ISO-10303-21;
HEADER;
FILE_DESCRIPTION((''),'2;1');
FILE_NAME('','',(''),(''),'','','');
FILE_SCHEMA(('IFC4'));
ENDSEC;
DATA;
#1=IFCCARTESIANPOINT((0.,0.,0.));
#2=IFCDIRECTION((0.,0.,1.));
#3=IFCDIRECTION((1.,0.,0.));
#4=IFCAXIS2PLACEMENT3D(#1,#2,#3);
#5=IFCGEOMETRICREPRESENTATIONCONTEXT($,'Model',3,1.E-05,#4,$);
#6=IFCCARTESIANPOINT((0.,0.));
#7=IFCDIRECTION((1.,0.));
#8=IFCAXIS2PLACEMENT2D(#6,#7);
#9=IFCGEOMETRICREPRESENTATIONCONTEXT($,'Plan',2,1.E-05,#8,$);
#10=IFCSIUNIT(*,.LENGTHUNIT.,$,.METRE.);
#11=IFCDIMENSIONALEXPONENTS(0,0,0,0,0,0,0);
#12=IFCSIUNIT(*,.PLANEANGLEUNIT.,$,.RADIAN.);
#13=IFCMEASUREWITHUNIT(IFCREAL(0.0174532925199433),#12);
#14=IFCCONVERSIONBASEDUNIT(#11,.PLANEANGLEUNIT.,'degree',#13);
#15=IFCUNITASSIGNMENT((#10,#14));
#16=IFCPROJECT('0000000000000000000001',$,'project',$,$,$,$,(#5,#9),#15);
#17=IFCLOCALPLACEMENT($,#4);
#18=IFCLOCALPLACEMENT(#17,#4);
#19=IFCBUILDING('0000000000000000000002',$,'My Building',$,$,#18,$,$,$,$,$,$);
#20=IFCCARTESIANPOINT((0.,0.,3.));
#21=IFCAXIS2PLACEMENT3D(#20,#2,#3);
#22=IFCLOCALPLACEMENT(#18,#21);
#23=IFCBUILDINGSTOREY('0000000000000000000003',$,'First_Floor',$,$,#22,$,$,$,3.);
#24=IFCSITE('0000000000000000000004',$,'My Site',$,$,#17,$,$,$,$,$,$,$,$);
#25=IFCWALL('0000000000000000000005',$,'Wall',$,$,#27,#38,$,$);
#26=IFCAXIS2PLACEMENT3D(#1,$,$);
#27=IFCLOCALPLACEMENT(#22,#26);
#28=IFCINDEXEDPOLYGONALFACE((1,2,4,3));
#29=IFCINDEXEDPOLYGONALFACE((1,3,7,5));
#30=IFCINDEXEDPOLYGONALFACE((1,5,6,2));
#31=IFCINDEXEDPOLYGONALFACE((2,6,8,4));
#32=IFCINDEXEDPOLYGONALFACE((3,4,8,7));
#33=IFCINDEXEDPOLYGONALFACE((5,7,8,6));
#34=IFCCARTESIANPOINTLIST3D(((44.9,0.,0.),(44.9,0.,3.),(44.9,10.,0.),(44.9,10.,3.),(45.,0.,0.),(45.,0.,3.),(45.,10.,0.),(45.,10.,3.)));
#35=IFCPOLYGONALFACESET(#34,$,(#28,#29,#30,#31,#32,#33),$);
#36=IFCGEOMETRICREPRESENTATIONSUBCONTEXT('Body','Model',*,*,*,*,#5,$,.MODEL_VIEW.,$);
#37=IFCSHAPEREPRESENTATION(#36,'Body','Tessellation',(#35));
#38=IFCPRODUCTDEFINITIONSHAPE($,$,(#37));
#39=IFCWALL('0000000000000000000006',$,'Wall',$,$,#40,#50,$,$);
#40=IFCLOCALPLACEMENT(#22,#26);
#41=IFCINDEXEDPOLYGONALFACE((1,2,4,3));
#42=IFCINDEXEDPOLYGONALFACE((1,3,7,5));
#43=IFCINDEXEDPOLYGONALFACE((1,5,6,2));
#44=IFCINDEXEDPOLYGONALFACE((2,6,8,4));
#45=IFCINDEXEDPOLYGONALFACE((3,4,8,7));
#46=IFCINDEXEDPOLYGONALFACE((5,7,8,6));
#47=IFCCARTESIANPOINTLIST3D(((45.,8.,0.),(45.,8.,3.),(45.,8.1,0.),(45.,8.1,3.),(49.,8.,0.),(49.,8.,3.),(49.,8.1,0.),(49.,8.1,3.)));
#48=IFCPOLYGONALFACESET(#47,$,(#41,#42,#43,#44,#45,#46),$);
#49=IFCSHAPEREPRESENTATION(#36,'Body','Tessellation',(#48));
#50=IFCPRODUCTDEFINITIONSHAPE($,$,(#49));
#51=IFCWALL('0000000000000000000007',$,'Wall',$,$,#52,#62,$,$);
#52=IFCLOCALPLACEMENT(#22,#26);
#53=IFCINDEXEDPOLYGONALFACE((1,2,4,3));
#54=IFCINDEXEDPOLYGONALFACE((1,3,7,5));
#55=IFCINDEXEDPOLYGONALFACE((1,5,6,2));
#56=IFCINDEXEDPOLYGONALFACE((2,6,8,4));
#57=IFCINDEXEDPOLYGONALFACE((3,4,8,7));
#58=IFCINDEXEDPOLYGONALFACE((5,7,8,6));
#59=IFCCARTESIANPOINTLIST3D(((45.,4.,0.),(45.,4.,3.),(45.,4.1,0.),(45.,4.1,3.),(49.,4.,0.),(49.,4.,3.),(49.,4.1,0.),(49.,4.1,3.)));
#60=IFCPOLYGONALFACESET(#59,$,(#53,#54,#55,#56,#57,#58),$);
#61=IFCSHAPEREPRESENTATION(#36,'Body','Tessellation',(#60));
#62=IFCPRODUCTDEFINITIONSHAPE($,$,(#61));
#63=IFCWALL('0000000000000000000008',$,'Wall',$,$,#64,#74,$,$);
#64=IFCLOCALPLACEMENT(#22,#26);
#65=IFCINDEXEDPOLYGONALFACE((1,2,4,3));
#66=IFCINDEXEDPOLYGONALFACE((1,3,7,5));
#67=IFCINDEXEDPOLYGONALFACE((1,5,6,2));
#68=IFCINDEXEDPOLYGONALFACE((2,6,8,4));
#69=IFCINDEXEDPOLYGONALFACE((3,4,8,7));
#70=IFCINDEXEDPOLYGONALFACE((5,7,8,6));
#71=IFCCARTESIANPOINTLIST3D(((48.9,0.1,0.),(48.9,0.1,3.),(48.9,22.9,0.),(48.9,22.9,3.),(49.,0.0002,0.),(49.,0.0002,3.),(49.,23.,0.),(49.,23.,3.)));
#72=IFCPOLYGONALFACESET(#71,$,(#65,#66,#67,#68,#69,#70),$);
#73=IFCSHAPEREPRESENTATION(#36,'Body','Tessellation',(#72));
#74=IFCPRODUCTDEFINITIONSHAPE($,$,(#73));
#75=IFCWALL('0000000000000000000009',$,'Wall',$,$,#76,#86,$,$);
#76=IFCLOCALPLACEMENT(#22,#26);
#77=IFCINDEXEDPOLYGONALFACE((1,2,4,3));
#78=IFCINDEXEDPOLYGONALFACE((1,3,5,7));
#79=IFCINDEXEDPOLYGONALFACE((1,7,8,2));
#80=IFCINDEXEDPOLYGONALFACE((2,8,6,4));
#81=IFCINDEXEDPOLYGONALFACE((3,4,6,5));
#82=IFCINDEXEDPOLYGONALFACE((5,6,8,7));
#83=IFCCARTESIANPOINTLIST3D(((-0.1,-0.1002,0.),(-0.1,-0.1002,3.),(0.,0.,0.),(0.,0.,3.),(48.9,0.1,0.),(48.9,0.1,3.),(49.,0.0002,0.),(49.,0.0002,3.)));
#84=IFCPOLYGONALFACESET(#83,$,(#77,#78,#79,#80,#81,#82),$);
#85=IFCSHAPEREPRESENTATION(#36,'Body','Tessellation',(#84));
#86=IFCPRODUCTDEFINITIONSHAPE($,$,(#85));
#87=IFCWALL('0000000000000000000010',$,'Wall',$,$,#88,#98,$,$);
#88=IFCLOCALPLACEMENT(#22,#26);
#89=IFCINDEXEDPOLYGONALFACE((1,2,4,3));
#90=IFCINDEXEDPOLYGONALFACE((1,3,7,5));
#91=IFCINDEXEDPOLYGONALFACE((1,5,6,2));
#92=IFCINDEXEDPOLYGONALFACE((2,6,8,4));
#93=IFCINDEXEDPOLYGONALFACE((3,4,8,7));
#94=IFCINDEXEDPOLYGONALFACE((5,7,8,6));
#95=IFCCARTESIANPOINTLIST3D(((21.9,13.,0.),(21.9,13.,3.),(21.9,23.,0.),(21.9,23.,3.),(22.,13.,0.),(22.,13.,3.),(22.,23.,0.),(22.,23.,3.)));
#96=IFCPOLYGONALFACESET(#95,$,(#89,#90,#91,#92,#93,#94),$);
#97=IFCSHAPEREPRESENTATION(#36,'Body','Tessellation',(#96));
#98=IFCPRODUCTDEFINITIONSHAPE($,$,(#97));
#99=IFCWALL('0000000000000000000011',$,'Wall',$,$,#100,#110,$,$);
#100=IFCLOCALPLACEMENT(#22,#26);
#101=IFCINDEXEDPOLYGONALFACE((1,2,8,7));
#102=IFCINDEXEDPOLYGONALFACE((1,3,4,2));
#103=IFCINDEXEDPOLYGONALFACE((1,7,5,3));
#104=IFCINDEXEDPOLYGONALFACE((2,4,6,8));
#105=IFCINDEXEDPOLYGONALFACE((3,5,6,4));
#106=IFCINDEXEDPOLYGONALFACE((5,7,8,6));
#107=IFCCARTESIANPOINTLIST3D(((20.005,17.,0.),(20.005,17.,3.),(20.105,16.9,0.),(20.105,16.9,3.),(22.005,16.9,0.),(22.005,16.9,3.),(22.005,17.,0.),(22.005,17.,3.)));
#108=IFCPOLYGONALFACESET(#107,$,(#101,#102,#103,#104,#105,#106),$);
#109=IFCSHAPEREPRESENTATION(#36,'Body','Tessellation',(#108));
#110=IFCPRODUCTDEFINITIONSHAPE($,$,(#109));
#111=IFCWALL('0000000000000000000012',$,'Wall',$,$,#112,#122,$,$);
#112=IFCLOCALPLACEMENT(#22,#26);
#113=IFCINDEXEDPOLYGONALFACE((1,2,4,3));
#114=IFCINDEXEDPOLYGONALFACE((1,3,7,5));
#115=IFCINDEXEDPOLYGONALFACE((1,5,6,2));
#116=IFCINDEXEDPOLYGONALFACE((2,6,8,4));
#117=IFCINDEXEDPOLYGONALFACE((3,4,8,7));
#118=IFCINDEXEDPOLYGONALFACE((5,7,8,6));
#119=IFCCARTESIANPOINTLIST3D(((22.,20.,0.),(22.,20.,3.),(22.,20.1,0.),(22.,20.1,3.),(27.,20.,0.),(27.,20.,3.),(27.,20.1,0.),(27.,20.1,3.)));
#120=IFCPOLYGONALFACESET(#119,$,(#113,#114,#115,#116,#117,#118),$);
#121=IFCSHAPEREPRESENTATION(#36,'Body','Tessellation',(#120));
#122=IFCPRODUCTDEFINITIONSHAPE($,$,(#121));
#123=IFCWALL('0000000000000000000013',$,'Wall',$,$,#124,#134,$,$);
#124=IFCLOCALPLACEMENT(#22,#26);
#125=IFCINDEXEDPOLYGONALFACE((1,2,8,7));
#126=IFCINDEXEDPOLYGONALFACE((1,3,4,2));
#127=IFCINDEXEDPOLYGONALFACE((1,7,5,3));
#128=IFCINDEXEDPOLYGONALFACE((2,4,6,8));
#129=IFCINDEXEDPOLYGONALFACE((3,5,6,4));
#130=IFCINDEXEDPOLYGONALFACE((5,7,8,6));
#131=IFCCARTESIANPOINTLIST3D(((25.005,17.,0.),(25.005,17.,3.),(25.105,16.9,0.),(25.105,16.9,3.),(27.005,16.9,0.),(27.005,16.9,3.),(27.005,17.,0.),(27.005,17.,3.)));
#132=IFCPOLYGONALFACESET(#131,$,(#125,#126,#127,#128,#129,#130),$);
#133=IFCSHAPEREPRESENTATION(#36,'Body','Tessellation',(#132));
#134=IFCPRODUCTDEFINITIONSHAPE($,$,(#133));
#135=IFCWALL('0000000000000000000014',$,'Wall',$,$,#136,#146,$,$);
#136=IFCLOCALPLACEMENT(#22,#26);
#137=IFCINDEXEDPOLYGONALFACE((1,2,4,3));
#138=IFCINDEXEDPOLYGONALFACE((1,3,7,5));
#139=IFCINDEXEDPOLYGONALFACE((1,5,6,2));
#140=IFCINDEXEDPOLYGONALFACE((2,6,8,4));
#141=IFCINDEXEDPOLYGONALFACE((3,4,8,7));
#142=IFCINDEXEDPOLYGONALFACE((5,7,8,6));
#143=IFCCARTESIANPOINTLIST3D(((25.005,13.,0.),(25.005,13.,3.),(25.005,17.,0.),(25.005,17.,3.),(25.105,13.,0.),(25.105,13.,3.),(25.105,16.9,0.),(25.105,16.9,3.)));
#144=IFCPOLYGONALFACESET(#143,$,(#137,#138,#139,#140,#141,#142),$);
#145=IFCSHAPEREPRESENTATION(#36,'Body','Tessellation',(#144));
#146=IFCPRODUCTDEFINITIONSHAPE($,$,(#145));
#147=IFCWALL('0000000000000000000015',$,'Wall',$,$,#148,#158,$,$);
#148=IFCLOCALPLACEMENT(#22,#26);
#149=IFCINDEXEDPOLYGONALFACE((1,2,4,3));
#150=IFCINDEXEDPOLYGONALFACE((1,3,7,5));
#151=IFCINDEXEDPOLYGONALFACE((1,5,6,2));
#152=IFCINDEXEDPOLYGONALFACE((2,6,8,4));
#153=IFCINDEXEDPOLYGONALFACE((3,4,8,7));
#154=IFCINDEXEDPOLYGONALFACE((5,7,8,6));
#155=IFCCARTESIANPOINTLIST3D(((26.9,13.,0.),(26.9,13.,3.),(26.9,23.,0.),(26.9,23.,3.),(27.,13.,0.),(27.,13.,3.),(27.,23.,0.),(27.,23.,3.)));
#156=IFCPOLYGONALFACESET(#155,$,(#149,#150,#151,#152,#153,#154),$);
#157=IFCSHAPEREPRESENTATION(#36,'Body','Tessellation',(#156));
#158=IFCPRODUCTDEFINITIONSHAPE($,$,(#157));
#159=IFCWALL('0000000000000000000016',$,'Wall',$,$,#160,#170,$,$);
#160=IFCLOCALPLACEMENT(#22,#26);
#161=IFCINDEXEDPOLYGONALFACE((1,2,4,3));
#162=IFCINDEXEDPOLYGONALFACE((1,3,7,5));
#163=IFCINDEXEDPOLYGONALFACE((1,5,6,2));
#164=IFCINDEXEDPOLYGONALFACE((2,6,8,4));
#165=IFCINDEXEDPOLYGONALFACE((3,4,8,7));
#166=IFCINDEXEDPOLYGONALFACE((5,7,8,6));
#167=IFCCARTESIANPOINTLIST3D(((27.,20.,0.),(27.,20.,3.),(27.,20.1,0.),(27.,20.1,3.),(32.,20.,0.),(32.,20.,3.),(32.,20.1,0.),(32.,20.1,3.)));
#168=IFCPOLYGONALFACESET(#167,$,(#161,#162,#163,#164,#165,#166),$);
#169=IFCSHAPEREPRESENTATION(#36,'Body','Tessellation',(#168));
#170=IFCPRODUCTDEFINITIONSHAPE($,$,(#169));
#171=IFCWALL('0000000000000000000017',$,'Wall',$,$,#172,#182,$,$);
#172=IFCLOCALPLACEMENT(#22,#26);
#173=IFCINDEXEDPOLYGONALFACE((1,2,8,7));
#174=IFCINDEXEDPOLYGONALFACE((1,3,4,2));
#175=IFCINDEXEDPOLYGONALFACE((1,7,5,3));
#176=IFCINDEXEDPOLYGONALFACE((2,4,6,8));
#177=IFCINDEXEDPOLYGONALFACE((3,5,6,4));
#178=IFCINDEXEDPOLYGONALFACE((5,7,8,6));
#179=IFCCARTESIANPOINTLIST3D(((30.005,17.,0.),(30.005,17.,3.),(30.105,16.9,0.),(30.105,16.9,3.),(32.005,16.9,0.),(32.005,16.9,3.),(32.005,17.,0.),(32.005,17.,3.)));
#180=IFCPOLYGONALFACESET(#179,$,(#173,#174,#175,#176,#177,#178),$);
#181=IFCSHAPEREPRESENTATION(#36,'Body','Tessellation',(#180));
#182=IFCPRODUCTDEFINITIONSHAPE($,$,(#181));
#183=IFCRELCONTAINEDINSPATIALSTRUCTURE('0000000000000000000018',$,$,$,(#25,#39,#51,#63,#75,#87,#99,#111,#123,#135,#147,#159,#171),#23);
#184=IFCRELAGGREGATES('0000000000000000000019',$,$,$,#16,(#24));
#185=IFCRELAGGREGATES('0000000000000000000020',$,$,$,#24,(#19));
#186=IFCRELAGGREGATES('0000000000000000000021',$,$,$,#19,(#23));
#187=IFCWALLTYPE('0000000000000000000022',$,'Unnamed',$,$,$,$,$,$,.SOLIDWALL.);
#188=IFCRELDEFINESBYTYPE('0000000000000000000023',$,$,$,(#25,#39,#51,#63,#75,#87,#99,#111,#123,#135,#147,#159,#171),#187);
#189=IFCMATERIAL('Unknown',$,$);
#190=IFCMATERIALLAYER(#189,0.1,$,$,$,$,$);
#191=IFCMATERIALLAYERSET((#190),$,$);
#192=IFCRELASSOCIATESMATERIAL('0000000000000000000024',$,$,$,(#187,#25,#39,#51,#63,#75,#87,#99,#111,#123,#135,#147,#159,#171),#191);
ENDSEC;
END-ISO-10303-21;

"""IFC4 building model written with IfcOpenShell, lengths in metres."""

from ifc_helpers import new_model, entity, si_unit, converted_unit, frame, origin_with_axes, origin_2d_with_axis, place, context, subcontext, project, spatial, line, indexed_curve, outline, extrude, material, layer, layer_set, layer_usage, type_object, element, save


model = new_model("IFC4")

# Units and contexts
model_context = context("Model", 3, precision=1e-05, world=origin_with_axes())
plan_context = context("Plan", 2, precision=1e-05, world=origin_2d_with_axis())
body_context = subcontext(model_context, "Body", "Model", "MODEL_VIEW")
ifc_project = project(units=[si_unit("LENGTHUNIT", "METRE"), converted_unit("PLANEANGLEUNIT", "degree", entity("IfcReal", 0.0174532925199433), si_unit("PLANEANGLEUNIT", "RADIAN"), dimensions=[0, 0, 0, 0, 0, 0, 0])], contexts=[model_context, plan_context])

# Site, building, storey
site_placement = place(None, origin_with_axes())
site = spatial("IfcSite", under=ifc_project, at=site_placement, Name="My Site")
building_placement = place(site_placement, origin_with_axes())
building = spatial("IfcBuilding", under=site, at=building_placement, Name="My Building")
storey_placement = place(building_placement, frame((0.0, 0.0, 3.0), z_axis=(0.0, 0.0, 1.0), x_axis=(1.0, 0.0, 0.0)))
storey = spatial("IfcBuildingStorey", under=building, at=storey_placement, Name="First_Floor", Elevation=3.0)

# Shared definitions
ifc_material = material(Name="Unknown")

# Walls
ifc_layer_1 = layer(ifc_material, 0.1)
ifc_layer_set_1 = layer_set([ifc_layer_1])
wall_type = type_object("IfcWallType", Name="Unnamed", PredefinedType="SOLIDWALL", material=ifc_layer_set_1)
ifc_layer_usage_1 = layer_usage(ifc_layer_set_1, "AXIS2", "POSITIVE", 0.0)
wall_1_placement = place(storey_placement, frame((44.9, 10.0, 0.0), z_axis=(0.0, 0.0, 1.0), x_axis=(0.0, -1.0, 0.0)))
element("IfcWall", 1, at=wall_1_placement, inside=storey, type_object=wall_type, material=ifc_layer_usage_1, Name="Wall", context=body_context, shape_type="SweptSolid", body=[
    extrude(outline(indexed_curve([(0.0, 0.0), (0.0, 0.1), (10.0, 0.1), (10.0, 0.0)], segments=[line(1, 2, 3, 4, 1)])), origin_with_axes(), (0.0, 0.0, 1.0), 3.0),
])
ifc_layer_usage_2 = layer_usage(ifc_layer_set_1, "AXIS2", "POSITIVE", 0.0)
wall_2_placement = place(storey_placement, frame((45.0, 8.0, 0.0), z_axis=(0.0, 0.0, 1.0), x_axis=(1.0, 0.0, 0.0)))
element("IfcWall", 2, at=wall_2_placement, inside=storey, type_object=wall_type, material=ifc_layer_usage_2, Name="Wall", context=body_context, shape_type="SweptSolid", body=[
    extrude(outline(indexed_curve([(0.0, 0.0), (0.0, 0.1), (4.0, 0.1), (4.0, 0.0)], segments=[line(1, 2, 3, 4, 1)])), origin_with_axes(), (0.0, 0.0, 1.0), 3.0),
])
ifc_layer_usage_3 = layer_usage(ifc_layer_set_1, "AXIS2", "POSITIVE", 0.0)
wall_3_placement = place(storey_placement, frame((45.0, 4.0, 0.0), z_axis=(0.0, 0.0, 1.0), x_axis=(1.0, 0.0, 0.0)))
element("IfcWall", 3, at=wall_3_placement, inside=storey, type_object=wall_type, material=ifc_layer_usage_3, Name="Wall", context=body_context, shape_type="SweptSolid", body=[
    extrude(outline(indexed_curve([(0.0, 0.0), (0.0, 0.1), (4.0, 0.1), (4.0, 0.0)], segments=[line(1, 2, 3, 4, 1)])), origin_with_axes(), (0.0, 0.0, 1.0), 3.0),
])
ifc_layer_usage_4 = layer_usage(ifc_layer_set_1, "AXIS2", "POSITIVE", 0.0)
wall_4_placement = place(storey_placement, frame((48.9, 22.9, 0.0), z_axis=(0.0, 0.0, 1.0), x_axis=(0.0, -1.0, 0.0)))
element("IfcWall", 4, at=wall_4_placement, inside=storey, type_object=wall_type, material=ifc_layer_usage_4, Name="Wall", context=body_context, shape_type="SweptSolid", body=[
    extrude(outline(indexed_curve([(0.0, 0.0), (-0.1, 0.1), (22.8998, 0.1), (22.8, 0.0)], segments=[line(1, 2, 3, 4, 1)])), origin_with_axes(), (0.0, 0.0, 1.0), 3.0),
])
ifc_layer_usage_5 = layer_usage(ifc_layer_set_1, "AXIS2", "POSITIVE", 0.0)
wall_5_placement = place(storey_placement, frame((48.9, 0.1, 0.0), z_axis=(0.0, 0.0, 1.0), x_axis=(-0.999998, -0.002045, 0.0)))
element("IfcWall", 5, at=wall_5_placement, inside=storey, type_object=wall_type, material=ifc_layer_usage_5, Name="Wall", context=body_context, shape_type="SweptSolid", body=[
    extrude(outline(indexed_curve([(0.0, 0.0), (-0.0998, 0.1), (49.0003, 0.1), (48.9001, 0.0)], segments=[line(1, 2, 3, 4, 1)])), origin_with_axes(), (0.0, 0.0, 1.0), 3.0),
])
ifc_layer_usage_6 = layer_usage(ifc_layer_set_1, "AXIS2", "POSITIVE", 0.0)
wall_6_placement = place(storey_placement, frame((21.9, 23.0, 0.0), z_axis=(0.0, 0.0, 1.0), x_axis=(0.0, -1.0, 0.0)))
element("IfcWall", 6, at=wall_6_placement, inside=storey, type_object=wall_type, material=ifc_layer_usage_6, Name="Wall", context=body_context, shape_type="SweptSolid", body=[
    extrude(outline(indexed_curve([(0.0, 0.0), (0.0, 0.1), (10.0, 0.1), (10.0, 0.0)], segments=[line(1, 2, 3, 4, 1)])), origin_with_axes(), (0.0, 0.0, 1.0), 3.0),
])
ifc_layer_usage_7 = layer_usage(ifc_layer_set_1, "AXIS2", "POSITIVE", 0.0)
wall_7_placement = place(storey_placement, frame((22.005, 17.0, 0.0), z_axis=(0.0, 0.0, 1.0), x_axis=(-1.0, 0.0, 0.0)))
element("IfcWall", 7, at=wall_7_placement, inside=storey, type_object=wall_type, material=ifc_layer_usage_7, Name="Wall", context=body_context, shape_type="SweptSolid", body=[
    extrude(outline(indexed_curve([(0.0, 0.0), (0.0, 0.1), (1.9, 0.1), (2.0, 0.0)], segments=[line(1, 2, 3, 4, 1)])), origin_with_axes(), (0.0, 0.0, 1.0), 3.0),
])
ifc_layer_usage_8 = layer_usage(ifc_layer_set_1, "AXIS2", "POSITIVE", 0.0)
wall_8_placement = place(storey_placement, frame((22.0, 20.0, 0.0), z_axis=(0.0, 0.0, 1.0), x_axis=(1.0, 0.0, 0.0)))
element("IfcWall", 8, at=wall_8_placement, inside=storey, type_object=wall_type, material=ifc_layer_usage_8, Name="Wall", context=body_context, shape_type="SweptSolid", body=[
    extrude(outline(indexed_curve([(0.0, 0.0), (0.0, 0.1), (5.0, 0.1), (5.0, 0.0)], segments=[line(1, 2, 3, 4, 1)])), origin_with_axes(), (0.0, 0.0, 1.0), 3.0),
])
ifc_layer_usage_9 = layer_usage(ifc_layer_set_1, "AXIS2", "POSITIVE", 0.0)
wall_9_placement = place(storey_placement, frame((27.005, 17.0, 0.0), z_axis=(0.0, 0.0, 1.0), x_axis=(-1.0, 0.0, 0.0)))
element("IfcWall", 9, at=wall_9_placement, inside=storey, type_object=wall_type, material=ifc_layer_usage_9, Name="Wall", context=body_context, shape_type="SweptSolid", body=[
    extrude(outline(indexed_curve([(0.0, 0.0), (0.0, 0.1), (1.9, 0.1), (2.0, 0.0)], segments=[line(1, 2, 3, 4, 1)])), origin_with_axes(), (0.0, 0.0, 1.0), 3.0),
])
ifc_layer_usage_10 = layer_usage(ifc_layer_set_1, "AXIS2", "POSITIVE", 0.0)
wall_10_placement = place(storey_placement, frame((25.005, 17.0, 0.0), z_axis=(0.0, 0.0, 1.0), x_axis=(0.0, -1.0, 0.0)))
element("IfcWall", 10, at=wall_10_placement, inside=storey, type_object=wall_type, material=ifc_layer_usage_10, Name="Wall", context=body_context, shape_type="SweptSolid", body=[
    extrude(outline(indexed_curve([(0.0, 0.0), (0.1, 0.1), (4.0, 0.1), (4.0, 0.0)], segments=[line(1, 2, 3, 4, 1)])), origin_with_axes(), (0.0, 0.0, 1.0), 3.0),
])
ifc_layer_usage_11 = layer_usage(ifc_layer_set_1, "AXIS2", "POSITIVE", 0.0)
wall_11_placement = place(storey_placement, frame((26.9, 23.0, 0.0), z_axis=(0.0, 0.0, 1.0), x_axis=(0.0, -1.0, 0.0)))
element("IfcWall", 11, at=wall_11_placement, inside=storey, type_object=wall_type, material=ifc_layer_usage_11, Name="Wall", context=body_context, shape_type="SweptSolid", body=[
    extrude(outline(indexed_curve([(0.0, 0.0), (0.0, 0.1), (10.0, 0.1), (10.0, 0.0)], segments=[line(1, 2, 3, 4, 1)])), origin_with_axes(), (0.0, 0.0, 1.0), 3.0),
])
ifc_layer_usage_12 = layer_usage(ifc_layer_set_1, "AXIS2", "POSITIVE", 0.0)
wall_12_placement = place(storey_placement, frame((27.0, 20.0, 0.0), z_axis=(0.0, 0.0, 1.0), x_axis=(1.0, 0.0, 0.0)))
element("IfcWall", 12, at=wall_12_placement, inside=storey, type_object=wall_type, material=ifc_layer_usage_12, Name="Wall", context=body_context, shape_type="SweptSolid", body=[
    extrude(outline(indexed_curve([(0.0, 0.0), (0.0, 0.1), (5.0, 0.1), (5.0, 0.0)], segments=[line(1, 2, 3, 4, 1)])), origin_with_axes(), (0.0, 0.0, 1.0), 3.0),
])
ifc_layer_usage_13 = layer_usage(ifc_layer_set_1, "AXIS2", "POSITIVE", 0.0)
wall_13_placement = place(storey_placement, frame((32.005, 17.0, 0.0), z_axis=(0.0, 0.0, 1.0), x_axis=(-1.0, 0.0, 0.0)))
element("IfcWall", 13, at=wall_13_placement, inside=storey, type_object=wall_type, material=ifc_layer_usage_13, Name="Wall", context=body_context, shape_type="SweptSolid", body=[
    extrude(outline(indexed_curve([(0.0, 0.0), (0.0, 0.1), (1.9, 0.1), (2.0, 0.0)], segments=[line(1, 2, 3, 4, 1)])), origin_with_axes(), (0.0, 0.0, 1.0), 3.0),
])

save(model, "model.ifc")
